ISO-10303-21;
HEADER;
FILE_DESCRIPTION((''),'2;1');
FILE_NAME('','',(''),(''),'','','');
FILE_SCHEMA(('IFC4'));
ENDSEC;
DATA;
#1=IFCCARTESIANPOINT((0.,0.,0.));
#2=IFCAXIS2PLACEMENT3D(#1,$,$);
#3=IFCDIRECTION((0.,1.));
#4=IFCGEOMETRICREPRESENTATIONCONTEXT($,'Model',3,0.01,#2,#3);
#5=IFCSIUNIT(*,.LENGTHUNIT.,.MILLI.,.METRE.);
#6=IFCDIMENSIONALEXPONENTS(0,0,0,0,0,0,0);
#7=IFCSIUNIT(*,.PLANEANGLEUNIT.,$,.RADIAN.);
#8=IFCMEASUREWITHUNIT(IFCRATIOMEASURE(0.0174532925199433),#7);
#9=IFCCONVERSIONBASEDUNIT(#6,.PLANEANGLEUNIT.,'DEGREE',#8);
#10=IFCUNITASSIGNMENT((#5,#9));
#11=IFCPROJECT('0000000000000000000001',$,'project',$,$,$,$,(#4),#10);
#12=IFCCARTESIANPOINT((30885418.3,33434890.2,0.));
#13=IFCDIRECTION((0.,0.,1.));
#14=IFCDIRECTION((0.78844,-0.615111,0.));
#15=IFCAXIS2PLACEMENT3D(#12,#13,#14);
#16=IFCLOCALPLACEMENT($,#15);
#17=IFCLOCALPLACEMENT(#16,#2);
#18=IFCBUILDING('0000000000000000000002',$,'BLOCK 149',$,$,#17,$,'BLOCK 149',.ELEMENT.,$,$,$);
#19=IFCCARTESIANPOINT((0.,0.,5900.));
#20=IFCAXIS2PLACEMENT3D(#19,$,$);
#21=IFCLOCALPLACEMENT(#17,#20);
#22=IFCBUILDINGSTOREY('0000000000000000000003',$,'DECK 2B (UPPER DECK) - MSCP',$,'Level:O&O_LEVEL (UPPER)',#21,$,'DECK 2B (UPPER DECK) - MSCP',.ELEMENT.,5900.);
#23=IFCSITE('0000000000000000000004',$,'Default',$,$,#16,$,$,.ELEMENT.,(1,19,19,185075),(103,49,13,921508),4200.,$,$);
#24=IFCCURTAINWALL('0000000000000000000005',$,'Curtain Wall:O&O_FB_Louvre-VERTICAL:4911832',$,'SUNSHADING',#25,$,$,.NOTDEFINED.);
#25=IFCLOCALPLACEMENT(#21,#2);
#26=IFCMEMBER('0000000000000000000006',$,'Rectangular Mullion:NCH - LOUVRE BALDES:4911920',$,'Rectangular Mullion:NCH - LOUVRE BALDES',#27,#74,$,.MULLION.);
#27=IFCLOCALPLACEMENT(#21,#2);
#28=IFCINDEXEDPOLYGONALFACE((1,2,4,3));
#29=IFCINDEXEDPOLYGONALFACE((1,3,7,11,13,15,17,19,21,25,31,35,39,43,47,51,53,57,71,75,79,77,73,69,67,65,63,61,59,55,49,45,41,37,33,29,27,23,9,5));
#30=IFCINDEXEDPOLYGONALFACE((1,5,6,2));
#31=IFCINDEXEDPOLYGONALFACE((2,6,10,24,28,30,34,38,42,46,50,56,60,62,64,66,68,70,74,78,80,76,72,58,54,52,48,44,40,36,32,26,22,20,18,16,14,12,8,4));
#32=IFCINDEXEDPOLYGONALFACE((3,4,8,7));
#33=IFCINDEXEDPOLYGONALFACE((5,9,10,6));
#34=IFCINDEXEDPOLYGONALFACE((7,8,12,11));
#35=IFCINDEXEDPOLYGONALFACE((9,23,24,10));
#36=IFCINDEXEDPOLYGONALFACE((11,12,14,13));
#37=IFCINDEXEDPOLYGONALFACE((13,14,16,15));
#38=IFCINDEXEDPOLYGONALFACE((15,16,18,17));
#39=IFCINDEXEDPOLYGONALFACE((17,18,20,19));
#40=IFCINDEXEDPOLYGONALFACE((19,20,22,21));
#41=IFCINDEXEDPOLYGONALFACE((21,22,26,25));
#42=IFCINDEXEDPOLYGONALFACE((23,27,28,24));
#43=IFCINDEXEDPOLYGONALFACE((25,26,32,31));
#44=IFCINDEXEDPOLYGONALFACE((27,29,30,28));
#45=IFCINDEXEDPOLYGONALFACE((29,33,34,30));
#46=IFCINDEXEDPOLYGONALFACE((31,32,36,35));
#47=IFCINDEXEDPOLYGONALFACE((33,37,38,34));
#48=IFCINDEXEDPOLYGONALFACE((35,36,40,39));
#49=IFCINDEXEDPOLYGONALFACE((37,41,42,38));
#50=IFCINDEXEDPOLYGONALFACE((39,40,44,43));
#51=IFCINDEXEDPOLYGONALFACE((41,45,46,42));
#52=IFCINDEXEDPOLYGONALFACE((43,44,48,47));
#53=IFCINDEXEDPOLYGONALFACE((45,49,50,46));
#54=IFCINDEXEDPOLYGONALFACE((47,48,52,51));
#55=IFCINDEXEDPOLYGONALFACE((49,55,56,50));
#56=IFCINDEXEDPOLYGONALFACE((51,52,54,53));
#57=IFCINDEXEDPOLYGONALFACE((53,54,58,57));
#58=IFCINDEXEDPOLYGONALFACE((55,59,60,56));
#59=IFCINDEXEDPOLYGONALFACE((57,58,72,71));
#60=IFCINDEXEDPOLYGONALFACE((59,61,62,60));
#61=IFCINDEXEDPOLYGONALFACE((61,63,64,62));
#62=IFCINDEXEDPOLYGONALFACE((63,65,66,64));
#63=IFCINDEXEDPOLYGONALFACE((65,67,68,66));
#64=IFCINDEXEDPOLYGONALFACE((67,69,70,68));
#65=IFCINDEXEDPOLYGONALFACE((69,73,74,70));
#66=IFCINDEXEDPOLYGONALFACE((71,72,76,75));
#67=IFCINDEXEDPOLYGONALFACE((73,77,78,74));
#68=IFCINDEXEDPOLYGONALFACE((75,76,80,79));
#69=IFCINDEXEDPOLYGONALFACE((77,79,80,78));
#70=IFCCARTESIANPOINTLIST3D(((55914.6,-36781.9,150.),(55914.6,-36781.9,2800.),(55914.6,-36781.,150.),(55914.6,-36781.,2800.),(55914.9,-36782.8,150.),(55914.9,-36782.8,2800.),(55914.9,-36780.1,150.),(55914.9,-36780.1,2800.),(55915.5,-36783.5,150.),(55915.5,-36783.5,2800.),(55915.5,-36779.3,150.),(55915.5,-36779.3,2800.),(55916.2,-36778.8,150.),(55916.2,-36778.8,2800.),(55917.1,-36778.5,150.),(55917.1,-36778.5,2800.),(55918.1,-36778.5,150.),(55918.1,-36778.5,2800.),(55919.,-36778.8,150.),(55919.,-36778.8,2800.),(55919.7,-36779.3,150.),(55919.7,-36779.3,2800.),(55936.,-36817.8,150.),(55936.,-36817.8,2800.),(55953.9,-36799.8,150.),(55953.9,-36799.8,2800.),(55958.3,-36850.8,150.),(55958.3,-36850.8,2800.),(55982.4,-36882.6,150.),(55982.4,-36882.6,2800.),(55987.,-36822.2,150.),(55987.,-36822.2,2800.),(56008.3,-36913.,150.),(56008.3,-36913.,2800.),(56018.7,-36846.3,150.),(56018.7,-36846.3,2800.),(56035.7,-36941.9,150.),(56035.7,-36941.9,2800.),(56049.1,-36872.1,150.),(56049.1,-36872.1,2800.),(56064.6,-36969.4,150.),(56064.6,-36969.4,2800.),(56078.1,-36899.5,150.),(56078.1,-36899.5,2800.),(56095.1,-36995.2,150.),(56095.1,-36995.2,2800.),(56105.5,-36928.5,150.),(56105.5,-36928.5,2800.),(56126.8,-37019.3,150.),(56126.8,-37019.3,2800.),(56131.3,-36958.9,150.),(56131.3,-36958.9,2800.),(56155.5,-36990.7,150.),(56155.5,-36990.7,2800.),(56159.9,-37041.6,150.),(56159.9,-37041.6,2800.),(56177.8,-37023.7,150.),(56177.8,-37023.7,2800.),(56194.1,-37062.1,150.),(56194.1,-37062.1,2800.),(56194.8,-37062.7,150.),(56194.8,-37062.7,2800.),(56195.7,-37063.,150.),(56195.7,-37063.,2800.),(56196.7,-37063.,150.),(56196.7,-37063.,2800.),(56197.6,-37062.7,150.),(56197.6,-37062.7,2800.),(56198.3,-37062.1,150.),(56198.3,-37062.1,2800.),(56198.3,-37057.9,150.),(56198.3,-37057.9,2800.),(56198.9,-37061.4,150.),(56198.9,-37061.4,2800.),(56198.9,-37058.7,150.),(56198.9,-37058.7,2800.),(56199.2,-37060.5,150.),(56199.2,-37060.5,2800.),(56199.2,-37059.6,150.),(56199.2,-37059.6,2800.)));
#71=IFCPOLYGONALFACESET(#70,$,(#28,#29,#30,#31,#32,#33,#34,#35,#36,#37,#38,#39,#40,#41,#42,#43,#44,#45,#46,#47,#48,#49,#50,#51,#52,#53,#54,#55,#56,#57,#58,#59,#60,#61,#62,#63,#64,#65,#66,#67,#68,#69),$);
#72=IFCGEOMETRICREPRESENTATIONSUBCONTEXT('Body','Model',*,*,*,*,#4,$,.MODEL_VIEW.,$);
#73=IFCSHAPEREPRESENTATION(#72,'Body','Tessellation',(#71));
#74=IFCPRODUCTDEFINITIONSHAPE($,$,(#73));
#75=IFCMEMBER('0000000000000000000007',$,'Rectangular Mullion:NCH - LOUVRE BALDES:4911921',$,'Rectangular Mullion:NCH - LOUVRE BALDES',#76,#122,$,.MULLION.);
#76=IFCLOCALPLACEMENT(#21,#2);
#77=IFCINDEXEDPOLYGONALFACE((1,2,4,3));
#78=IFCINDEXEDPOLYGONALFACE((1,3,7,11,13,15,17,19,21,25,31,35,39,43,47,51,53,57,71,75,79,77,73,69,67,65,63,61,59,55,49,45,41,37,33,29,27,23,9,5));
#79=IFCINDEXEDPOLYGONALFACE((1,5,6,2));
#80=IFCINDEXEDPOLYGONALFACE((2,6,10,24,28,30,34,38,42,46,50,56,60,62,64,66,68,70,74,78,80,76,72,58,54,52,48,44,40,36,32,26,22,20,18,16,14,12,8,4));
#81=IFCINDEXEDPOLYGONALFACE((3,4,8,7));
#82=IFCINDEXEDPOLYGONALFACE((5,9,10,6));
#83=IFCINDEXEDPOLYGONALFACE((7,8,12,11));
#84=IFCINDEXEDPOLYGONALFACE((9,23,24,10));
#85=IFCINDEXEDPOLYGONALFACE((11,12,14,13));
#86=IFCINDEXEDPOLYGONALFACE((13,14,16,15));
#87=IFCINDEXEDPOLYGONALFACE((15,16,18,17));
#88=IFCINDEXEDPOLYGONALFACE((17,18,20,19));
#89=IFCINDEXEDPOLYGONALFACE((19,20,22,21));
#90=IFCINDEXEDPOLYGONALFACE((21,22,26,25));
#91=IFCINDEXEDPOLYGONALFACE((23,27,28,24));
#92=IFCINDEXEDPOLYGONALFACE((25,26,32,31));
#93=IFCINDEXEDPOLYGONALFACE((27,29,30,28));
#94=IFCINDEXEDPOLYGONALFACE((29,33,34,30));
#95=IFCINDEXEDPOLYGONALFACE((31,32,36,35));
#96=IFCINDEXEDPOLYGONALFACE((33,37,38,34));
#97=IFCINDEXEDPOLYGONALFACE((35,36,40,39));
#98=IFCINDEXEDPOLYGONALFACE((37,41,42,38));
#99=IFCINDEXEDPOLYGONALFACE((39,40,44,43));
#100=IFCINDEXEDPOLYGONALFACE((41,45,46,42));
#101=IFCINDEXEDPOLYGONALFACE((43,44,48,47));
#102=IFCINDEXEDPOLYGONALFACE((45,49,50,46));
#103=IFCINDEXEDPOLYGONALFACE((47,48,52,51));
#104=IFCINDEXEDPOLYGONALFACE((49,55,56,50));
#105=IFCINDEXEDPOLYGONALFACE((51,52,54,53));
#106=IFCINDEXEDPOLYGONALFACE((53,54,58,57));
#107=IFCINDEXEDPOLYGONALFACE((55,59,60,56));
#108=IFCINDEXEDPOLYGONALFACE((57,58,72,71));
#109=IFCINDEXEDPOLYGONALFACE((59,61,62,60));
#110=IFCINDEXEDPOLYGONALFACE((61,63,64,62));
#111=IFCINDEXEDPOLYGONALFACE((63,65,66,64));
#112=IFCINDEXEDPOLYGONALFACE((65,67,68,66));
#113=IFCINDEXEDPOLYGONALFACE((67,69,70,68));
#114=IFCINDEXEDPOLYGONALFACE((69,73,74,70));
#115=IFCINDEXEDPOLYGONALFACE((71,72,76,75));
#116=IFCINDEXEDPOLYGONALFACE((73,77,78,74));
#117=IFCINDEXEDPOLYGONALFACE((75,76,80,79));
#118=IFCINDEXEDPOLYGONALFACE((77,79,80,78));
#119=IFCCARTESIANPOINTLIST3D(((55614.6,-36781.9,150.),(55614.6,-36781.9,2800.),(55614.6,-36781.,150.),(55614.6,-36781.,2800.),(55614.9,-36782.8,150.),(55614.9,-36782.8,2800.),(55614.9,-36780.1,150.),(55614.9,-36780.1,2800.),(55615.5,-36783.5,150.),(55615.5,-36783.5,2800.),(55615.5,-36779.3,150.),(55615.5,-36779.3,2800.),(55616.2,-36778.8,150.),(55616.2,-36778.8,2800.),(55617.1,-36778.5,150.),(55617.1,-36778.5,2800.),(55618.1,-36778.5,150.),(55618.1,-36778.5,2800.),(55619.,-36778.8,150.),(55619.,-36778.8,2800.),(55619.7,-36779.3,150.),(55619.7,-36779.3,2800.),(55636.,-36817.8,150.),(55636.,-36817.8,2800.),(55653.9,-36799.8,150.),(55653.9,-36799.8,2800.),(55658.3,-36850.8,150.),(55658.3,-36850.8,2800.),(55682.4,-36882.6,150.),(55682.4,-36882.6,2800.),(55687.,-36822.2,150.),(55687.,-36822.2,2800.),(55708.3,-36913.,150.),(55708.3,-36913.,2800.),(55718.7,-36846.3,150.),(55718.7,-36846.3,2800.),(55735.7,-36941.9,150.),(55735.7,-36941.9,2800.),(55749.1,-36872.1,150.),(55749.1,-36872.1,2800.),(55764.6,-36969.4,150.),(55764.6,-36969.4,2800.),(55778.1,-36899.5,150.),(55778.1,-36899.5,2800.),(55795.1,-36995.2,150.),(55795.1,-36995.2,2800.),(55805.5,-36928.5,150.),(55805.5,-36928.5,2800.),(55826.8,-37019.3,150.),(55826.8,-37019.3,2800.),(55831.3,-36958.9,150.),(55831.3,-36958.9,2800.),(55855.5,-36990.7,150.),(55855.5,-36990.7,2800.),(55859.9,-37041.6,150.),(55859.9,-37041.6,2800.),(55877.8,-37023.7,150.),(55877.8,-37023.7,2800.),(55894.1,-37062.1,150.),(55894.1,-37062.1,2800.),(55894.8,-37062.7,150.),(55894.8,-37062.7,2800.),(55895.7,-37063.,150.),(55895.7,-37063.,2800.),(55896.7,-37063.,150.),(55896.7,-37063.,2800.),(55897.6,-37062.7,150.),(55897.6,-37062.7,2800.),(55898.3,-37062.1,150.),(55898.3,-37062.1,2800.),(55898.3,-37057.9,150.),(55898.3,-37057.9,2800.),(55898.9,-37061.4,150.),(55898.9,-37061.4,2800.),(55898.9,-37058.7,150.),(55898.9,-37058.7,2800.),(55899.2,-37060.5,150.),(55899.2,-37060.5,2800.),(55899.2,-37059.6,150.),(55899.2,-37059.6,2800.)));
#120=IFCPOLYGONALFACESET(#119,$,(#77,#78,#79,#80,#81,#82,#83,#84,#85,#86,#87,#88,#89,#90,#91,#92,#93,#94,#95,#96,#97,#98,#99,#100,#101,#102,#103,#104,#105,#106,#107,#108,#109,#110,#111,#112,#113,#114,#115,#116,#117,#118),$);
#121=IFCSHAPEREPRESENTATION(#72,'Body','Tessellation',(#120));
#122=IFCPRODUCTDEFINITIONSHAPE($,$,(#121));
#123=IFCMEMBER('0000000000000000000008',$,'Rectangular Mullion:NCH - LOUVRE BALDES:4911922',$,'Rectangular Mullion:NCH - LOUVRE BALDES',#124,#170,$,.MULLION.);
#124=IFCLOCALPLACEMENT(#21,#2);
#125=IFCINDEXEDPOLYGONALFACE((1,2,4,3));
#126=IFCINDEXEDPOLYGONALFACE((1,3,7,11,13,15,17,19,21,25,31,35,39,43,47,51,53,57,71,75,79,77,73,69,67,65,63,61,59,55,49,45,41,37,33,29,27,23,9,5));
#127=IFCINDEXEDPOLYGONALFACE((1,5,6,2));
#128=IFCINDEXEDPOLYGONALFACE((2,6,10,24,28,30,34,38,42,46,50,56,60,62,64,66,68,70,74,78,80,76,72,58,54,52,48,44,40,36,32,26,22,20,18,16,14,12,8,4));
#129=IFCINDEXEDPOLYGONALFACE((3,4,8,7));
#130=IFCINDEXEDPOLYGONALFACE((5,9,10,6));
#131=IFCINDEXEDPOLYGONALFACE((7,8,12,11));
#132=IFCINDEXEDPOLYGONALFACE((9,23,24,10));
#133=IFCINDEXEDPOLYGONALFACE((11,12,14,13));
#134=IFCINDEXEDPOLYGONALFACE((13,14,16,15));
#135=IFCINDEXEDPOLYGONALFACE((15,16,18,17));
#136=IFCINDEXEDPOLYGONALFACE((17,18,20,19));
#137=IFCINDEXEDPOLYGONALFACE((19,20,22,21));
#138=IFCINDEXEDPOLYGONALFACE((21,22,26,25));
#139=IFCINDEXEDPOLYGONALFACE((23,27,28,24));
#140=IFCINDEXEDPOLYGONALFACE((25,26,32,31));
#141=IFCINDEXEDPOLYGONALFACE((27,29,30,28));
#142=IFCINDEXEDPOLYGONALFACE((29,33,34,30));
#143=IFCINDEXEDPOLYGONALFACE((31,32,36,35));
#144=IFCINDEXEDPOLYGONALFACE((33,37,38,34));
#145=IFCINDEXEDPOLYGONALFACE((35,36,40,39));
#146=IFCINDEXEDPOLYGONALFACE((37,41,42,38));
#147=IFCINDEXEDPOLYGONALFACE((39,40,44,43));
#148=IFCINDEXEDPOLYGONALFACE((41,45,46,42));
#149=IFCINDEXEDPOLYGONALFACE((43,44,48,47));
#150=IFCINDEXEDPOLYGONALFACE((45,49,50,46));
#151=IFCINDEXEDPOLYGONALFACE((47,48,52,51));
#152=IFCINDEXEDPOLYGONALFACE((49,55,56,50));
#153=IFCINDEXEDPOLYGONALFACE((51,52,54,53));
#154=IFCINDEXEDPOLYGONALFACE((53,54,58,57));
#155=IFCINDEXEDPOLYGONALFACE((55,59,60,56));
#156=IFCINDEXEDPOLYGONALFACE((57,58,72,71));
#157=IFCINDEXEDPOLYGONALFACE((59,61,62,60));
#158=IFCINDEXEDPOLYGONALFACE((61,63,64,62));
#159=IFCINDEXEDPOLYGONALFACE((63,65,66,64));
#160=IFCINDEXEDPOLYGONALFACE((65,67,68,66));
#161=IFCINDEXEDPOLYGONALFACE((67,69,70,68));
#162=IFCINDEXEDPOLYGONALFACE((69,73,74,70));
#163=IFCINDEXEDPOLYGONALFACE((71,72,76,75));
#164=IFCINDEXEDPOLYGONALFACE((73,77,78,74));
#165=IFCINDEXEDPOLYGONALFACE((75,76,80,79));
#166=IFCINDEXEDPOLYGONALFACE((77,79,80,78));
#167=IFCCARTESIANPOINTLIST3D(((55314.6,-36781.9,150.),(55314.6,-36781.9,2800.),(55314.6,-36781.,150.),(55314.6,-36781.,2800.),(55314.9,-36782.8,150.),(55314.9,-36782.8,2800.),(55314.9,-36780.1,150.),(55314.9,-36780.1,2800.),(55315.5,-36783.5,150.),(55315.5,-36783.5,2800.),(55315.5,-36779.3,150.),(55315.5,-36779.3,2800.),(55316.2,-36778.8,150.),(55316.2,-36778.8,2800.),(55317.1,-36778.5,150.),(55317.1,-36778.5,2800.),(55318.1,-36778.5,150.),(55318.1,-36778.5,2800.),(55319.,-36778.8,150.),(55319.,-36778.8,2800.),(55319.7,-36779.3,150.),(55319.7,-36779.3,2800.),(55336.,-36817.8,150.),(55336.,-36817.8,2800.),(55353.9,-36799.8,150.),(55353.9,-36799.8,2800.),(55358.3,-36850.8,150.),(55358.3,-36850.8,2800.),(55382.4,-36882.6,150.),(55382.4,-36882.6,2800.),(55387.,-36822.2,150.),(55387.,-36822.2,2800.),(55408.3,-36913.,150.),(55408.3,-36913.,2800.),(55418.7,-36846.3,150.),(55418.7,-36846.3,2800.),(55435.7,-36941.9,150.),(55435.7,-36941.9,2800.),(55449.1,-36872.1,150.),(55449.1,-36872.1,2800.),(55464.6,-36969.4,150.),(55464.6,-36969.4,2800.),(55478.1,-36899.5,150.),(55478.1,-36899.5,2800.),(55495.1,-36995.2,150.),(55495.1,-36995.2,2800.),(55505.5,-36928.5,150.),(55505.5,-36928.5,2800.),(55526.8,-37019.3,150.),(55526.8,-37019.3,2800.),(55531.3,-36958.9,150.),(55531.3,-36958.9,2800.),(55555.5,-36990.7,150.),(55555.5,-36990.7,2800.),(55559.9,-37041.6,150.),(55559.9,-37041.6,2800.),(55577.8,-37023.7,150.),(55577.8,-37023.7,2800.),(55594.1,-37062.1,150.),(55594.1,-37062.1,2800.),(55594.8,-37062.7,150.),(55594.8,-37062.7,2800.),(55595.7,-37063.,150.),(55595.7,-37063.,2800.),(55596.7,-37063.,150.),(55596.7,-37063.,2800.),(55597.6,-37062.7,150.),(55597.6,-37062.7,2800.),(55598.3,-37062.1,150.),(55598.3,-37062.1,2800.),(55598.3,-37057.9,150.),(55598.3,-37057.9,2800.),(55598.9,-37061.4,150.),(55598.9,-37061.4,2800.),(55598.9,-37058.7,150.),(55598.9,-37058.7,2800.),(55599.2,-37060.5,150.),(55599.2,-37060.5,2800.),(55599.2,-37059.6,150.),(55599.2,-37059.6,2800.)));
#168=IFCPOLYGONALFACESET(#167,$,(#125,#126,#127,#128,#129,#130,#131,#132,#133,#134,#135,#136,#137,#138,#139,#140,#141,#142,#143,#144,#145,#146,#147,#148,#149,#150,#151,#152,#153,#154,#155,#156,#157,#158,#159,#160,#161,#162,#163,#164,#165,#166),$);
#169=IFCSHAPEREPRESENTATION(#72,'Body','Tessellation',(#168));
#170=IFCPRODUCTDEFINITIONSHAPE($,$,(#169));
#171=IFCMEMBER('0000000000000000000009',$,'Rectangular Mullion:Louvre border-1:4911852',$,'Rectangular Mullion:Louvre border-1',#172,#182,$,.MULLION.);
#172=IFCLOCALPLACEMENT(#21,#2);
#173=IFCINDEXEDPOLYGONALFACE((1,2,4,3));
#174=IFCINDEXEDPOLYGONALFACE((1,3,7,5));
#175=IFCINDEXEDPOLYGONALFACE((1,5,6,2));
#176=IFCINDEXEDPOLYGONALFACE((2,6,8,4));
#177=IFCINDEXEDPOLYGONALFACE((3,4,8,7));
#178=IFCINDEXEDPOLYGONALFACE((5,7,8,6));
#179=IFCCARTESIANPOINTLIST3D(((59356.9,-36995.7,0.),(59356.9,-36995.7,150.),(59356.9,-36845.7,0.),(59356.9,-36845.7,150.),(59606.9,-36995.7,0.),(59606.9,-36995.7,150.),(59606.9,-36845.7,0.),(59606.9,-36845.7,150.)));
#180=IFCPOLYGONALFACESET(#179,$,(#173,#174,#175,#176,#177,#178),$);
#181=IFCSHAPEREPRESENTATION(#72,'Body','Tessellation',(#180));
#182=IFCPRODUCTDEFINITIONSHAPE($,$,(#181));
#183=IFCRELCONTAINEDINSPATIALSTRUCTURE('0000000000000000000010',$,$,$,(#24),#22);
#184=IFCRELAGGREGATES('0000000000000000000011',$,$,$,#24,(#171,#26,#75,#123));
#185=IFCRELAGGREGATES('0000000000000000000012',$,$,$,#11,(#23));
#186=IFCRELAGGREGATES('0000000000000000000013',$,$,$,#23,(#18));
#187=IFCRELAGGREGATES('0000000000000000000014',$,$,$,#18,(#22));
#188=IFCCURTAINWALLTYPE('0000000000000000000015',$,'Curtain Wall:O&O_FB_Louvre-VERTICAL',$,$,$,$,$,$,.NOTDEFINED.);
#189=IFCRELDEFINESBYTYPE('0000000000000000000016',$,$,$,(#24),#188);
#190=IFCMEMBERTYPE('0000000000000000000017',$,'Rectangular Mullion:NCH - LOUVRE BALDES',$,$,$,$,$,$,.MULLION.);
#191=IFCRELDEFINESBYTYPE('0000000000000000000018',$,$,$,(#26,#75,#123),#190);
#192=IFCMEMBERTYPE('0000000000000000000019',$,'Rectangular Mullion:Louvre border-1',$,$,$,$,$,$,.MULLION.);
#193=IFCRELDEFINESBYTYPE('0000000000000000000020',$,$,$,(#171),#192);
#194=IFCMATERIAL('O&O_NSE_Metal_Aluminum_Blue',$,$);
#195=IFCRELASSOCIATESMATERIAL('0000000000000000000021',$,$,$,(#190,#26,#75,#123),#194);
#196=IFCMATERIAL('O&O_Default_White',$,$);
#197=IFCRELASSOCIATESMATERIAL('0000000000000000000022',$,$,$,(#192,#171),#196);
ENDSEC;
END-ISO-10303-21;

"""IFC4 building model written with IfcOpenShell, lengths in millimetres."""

from ifc_helpers import new_model, entity, si_unit, converted_unit, direction, frame, origin, place, context, subcontext, project, spatial, indexed_curve, outline, extrude, source, transform, mapped, material, type_object, type_shapes, element, aggregate, save


model = new_model("IFC4")

# Units and contexts
model_context = context("Model", 3, precision=0.01, world=origin(), true_north=direction((0.0, 1.0)))
body_context = subcontext(model_context, "Body", "Model", "MODEL_VIEW")
ifc_project = project(units=[si_unit("LENGTHUNIT", "METRE", prefix="MILLI"), converted_unit("PLANEANGLEUNIT", "DEGREE", entity("IfcRatioMeasure", 0.0174532925199433), si_unit("PLANEANGLEUNIT", "RADIAN"), dimensions=[0, 0, 0, 0, 0, 0, 0])], contexts=[model_context])

# Site, building, storey
site_placement = place(None, frame((30885418.3, 33434890.2, 0.0), z_axis=(0.0, 0.0, 1.0), x_axis=(0.78844, -0.615111, 0.0)))
site = spatial("IfcSite", under=ifc_project, at=site_placement, Name="Default", CompositionType="ELEMENT", RefLatitude=(1, 19, 19, 185075), RefLongitude=(103, 49, 13, 921508), RefElevation=4200.0)
building_placement = place(site_placement, origin())
building = spatial("IfcBuilding", under=site, at=building_placement, Name="BLOCK 149", LongName="BLOCK 149", CompositionType="ELEMENT")
storey_placement = place(building_placement, frame((0.0, 0.0, 5900.0)))
storey = spatial("IfcBuildingStorey", under=building, at=storey_placement, Name="DECK 2B (UPPER DECK) - MSCP", ObjectType="Level:O&O_LEVEL (UPPER)", LongName="DECK 2B (UPPER DECK) - MSCP", CompositionType="ELEMENT", Elevation=5900.0)

# Curtain wall, members
curtain_wall_type = type_object("IfcCurtainWallType", Name="Curtain Wall:O&O_FB_Louvre-VERTICAL", PredefinedType="NOTDEFINED")
curtain_wall_placement = place(storey_placement, frame((0.0, 0.0, -5900.0)))
curtain_wall = element("IfcCurtainWall", 1, at=curtain_wall_placement, inside=storey, type_object=curtain_wall_type, Name="Curtain Wall:O&O_FB_Louvre-VERTICAL:4911832", ObjectType="SUNSHADING", PredefinedType="NOTDEFINED")
ifc_material_1 = material(Name="O&O_Default_White")
placement = place(building_placement, origin())
ifc_material_2 = material(Name="O&O_NSE_Metal_Aluminum_Blue")
member_type_1 = type_object("IfcMemberType", Name="Rectangular Mullion:NCH - LOUVRE BALDES", PredefinedType="MULLION", material=ifc_material_2)
shared_shape_1 = source(origin(), body_context, "Body", "SweptSolid", [
    extrude(outline(indexed_curve([(55.9, -188.9), (54.8, -149.1), (51.6, -109.3), (46.1, -69.8), (38.6, -30.6), (28.9, 8.1), (17.1, 46.2), (3.3, 83.6), (-12.6, 120.2), (-30.4, 155.9), (-50.1, 190.5), (-50.5, 191.4), (-51.1, 192.1), (-52.0, 192.5), (-52.9, 192.7), (-53.8, 192.6), (-54.7, 192.2), (-55.4, 191.6), (-55.8, 190.8), (-56.0, 189.9), (-55.9, 188.9), (-54.8, 149.1), (-51.6, 109.3), (-46.1, 69.8), (-38.6, 30.6), (-28.9, -8.1), (-17.1, -46.2), (-3.3, -83.6), (12.6, -120.2), (30.4, -155.9), (50.1, -190.5), (50.5, -191.4), (51.1, -192.1), (52.0, -192.5), (52.9, -192.7), (53.8, -192.6), (54.7, -192.2), (55.4, -191.6), (55.8, -190.8), (56.0, -189.9), (55.9, -188.9)], self_intersect=False)), frame((0.0, 0.0, -2650.0), z_axis=(0.0, 0.0, 1.0), x_axis=(0.490779, -0.871284, 0.0)), (0.0, 0.0, 1.0), 2650.0),
])
type_shapes(member_type_1, [shared_shape_1])
member_1_placement = place(placement, frame((56056.9, -36920.7, 6050.0), z_axis=(0.0, 0.0, -1.0), x_axis=(-1.0, 0.0, 0.0)))
member_1 = element("IfcMember", 2, at=member_1_placement, type_object=member_type_1, material=ifc_material_2, Name="Rectangular Mullion:NCH - LOUVRE BALDES:4911920", ObjectType="Rectangular Mullion:NCH - LOUVRE BALDES", PredefinedType="MULLION", context=body_context, shape_type="MappedRepresentation", body=[
    mapped(shared_shape_1, transform((0.0, 0.0, 0.0), scale=1.0)),
])
member_2_placement = place(placement, frame((55756.9, -36920.7, 6050.0), z_axis=(0.0, 0.0, -1.0), x_axis=(-1.0, 0.0, 0.0)))
member_2 = element("IfcMember", 3, at=member_2_placement, type_object=member_type_1, material=ifc_material_2, Name="Rectangular Mullion:NCH - LOUVRE BALDES:4911921", ObjectType="Rectangular Mullion:NCH - LOUVRE BALDES", PredefinedType="MULLION", context=body_context, shape_type="MappedRepresentation", body=[
    mapped(shared_shape_1, transform((0.0, 0.0, 0.0), scale=1.0)),
])
member_3_placement = place(placement, frame((55456.9, -36920.7, 6050.0), z_axis=(0.0, 0.0, -1.0), x_axis=(-1.0, 0.0, 0.0)))
member_3 = element("IfcMember", 4, at=member_3_placement, type_object=member_type_1, material=ifc_material_2, Name="Rectangular Mullion:NCH - LOUVRE BALDES:4911922", ObjectType="Rectangular Mullion:NCH - LOUVRE BALDES", PredefinedType="MULLION", context=body_context, shape_type="MappedRepresentation", body=[
    mapped(shared_shape_1, transform((0.0, 0.0, 0.0), scale=1.0)),
])
member_type_2 = type_object("IfcMemberType", Name="Rectangular Mullion:Louvre border-1", PredefinedType="MULLION", material=ifc_material_1)
shared_shape_2 = source(origin(), body_context, "Body", "SweptSolid", [
    extrude(outline(indexed_curve([(-75.0, -75.0), (75.0, -75.0), (75.0, 75.0), (-75.0, 75.0), (-75.0, -75.0)], self_intersect=False)), frame((-75.0, 0.0, -250.0), z_axis=(0.0, 0.0, 1.0), x_axis=(0.0, -1.0, 0.0)), (0.0, 0.0, 1.0), 250.0),
])
type_shapes(member_type_2, [shared_shape_2])
member_4_placement = place(placement, frame((59606.9, -36920.7, 5900.0), z_axis=(1.0, 0.0, 0.0), x_axis=(0.0, 0.0, -1.0)))
member_4 = element("IfcMember", 5, at=member_4_placement, type_object=member_type_2, material=ifc_material_1, Name="Rectangular Mullion:Louvre border-1:4911852", ObjectType="Rectangular Mullion:Louvre border-1", PredefinedType="MULLION", context=body_context, shape_type="MappedRepresentation", body=[
    mapped(shared_shape_2, transform((0.0, 0.0, 0.0), scale=1.0)),
])
aggregate(curtain_wall, [member_4, member_1, member_2, member_3])

save(model, "model.ifc")
